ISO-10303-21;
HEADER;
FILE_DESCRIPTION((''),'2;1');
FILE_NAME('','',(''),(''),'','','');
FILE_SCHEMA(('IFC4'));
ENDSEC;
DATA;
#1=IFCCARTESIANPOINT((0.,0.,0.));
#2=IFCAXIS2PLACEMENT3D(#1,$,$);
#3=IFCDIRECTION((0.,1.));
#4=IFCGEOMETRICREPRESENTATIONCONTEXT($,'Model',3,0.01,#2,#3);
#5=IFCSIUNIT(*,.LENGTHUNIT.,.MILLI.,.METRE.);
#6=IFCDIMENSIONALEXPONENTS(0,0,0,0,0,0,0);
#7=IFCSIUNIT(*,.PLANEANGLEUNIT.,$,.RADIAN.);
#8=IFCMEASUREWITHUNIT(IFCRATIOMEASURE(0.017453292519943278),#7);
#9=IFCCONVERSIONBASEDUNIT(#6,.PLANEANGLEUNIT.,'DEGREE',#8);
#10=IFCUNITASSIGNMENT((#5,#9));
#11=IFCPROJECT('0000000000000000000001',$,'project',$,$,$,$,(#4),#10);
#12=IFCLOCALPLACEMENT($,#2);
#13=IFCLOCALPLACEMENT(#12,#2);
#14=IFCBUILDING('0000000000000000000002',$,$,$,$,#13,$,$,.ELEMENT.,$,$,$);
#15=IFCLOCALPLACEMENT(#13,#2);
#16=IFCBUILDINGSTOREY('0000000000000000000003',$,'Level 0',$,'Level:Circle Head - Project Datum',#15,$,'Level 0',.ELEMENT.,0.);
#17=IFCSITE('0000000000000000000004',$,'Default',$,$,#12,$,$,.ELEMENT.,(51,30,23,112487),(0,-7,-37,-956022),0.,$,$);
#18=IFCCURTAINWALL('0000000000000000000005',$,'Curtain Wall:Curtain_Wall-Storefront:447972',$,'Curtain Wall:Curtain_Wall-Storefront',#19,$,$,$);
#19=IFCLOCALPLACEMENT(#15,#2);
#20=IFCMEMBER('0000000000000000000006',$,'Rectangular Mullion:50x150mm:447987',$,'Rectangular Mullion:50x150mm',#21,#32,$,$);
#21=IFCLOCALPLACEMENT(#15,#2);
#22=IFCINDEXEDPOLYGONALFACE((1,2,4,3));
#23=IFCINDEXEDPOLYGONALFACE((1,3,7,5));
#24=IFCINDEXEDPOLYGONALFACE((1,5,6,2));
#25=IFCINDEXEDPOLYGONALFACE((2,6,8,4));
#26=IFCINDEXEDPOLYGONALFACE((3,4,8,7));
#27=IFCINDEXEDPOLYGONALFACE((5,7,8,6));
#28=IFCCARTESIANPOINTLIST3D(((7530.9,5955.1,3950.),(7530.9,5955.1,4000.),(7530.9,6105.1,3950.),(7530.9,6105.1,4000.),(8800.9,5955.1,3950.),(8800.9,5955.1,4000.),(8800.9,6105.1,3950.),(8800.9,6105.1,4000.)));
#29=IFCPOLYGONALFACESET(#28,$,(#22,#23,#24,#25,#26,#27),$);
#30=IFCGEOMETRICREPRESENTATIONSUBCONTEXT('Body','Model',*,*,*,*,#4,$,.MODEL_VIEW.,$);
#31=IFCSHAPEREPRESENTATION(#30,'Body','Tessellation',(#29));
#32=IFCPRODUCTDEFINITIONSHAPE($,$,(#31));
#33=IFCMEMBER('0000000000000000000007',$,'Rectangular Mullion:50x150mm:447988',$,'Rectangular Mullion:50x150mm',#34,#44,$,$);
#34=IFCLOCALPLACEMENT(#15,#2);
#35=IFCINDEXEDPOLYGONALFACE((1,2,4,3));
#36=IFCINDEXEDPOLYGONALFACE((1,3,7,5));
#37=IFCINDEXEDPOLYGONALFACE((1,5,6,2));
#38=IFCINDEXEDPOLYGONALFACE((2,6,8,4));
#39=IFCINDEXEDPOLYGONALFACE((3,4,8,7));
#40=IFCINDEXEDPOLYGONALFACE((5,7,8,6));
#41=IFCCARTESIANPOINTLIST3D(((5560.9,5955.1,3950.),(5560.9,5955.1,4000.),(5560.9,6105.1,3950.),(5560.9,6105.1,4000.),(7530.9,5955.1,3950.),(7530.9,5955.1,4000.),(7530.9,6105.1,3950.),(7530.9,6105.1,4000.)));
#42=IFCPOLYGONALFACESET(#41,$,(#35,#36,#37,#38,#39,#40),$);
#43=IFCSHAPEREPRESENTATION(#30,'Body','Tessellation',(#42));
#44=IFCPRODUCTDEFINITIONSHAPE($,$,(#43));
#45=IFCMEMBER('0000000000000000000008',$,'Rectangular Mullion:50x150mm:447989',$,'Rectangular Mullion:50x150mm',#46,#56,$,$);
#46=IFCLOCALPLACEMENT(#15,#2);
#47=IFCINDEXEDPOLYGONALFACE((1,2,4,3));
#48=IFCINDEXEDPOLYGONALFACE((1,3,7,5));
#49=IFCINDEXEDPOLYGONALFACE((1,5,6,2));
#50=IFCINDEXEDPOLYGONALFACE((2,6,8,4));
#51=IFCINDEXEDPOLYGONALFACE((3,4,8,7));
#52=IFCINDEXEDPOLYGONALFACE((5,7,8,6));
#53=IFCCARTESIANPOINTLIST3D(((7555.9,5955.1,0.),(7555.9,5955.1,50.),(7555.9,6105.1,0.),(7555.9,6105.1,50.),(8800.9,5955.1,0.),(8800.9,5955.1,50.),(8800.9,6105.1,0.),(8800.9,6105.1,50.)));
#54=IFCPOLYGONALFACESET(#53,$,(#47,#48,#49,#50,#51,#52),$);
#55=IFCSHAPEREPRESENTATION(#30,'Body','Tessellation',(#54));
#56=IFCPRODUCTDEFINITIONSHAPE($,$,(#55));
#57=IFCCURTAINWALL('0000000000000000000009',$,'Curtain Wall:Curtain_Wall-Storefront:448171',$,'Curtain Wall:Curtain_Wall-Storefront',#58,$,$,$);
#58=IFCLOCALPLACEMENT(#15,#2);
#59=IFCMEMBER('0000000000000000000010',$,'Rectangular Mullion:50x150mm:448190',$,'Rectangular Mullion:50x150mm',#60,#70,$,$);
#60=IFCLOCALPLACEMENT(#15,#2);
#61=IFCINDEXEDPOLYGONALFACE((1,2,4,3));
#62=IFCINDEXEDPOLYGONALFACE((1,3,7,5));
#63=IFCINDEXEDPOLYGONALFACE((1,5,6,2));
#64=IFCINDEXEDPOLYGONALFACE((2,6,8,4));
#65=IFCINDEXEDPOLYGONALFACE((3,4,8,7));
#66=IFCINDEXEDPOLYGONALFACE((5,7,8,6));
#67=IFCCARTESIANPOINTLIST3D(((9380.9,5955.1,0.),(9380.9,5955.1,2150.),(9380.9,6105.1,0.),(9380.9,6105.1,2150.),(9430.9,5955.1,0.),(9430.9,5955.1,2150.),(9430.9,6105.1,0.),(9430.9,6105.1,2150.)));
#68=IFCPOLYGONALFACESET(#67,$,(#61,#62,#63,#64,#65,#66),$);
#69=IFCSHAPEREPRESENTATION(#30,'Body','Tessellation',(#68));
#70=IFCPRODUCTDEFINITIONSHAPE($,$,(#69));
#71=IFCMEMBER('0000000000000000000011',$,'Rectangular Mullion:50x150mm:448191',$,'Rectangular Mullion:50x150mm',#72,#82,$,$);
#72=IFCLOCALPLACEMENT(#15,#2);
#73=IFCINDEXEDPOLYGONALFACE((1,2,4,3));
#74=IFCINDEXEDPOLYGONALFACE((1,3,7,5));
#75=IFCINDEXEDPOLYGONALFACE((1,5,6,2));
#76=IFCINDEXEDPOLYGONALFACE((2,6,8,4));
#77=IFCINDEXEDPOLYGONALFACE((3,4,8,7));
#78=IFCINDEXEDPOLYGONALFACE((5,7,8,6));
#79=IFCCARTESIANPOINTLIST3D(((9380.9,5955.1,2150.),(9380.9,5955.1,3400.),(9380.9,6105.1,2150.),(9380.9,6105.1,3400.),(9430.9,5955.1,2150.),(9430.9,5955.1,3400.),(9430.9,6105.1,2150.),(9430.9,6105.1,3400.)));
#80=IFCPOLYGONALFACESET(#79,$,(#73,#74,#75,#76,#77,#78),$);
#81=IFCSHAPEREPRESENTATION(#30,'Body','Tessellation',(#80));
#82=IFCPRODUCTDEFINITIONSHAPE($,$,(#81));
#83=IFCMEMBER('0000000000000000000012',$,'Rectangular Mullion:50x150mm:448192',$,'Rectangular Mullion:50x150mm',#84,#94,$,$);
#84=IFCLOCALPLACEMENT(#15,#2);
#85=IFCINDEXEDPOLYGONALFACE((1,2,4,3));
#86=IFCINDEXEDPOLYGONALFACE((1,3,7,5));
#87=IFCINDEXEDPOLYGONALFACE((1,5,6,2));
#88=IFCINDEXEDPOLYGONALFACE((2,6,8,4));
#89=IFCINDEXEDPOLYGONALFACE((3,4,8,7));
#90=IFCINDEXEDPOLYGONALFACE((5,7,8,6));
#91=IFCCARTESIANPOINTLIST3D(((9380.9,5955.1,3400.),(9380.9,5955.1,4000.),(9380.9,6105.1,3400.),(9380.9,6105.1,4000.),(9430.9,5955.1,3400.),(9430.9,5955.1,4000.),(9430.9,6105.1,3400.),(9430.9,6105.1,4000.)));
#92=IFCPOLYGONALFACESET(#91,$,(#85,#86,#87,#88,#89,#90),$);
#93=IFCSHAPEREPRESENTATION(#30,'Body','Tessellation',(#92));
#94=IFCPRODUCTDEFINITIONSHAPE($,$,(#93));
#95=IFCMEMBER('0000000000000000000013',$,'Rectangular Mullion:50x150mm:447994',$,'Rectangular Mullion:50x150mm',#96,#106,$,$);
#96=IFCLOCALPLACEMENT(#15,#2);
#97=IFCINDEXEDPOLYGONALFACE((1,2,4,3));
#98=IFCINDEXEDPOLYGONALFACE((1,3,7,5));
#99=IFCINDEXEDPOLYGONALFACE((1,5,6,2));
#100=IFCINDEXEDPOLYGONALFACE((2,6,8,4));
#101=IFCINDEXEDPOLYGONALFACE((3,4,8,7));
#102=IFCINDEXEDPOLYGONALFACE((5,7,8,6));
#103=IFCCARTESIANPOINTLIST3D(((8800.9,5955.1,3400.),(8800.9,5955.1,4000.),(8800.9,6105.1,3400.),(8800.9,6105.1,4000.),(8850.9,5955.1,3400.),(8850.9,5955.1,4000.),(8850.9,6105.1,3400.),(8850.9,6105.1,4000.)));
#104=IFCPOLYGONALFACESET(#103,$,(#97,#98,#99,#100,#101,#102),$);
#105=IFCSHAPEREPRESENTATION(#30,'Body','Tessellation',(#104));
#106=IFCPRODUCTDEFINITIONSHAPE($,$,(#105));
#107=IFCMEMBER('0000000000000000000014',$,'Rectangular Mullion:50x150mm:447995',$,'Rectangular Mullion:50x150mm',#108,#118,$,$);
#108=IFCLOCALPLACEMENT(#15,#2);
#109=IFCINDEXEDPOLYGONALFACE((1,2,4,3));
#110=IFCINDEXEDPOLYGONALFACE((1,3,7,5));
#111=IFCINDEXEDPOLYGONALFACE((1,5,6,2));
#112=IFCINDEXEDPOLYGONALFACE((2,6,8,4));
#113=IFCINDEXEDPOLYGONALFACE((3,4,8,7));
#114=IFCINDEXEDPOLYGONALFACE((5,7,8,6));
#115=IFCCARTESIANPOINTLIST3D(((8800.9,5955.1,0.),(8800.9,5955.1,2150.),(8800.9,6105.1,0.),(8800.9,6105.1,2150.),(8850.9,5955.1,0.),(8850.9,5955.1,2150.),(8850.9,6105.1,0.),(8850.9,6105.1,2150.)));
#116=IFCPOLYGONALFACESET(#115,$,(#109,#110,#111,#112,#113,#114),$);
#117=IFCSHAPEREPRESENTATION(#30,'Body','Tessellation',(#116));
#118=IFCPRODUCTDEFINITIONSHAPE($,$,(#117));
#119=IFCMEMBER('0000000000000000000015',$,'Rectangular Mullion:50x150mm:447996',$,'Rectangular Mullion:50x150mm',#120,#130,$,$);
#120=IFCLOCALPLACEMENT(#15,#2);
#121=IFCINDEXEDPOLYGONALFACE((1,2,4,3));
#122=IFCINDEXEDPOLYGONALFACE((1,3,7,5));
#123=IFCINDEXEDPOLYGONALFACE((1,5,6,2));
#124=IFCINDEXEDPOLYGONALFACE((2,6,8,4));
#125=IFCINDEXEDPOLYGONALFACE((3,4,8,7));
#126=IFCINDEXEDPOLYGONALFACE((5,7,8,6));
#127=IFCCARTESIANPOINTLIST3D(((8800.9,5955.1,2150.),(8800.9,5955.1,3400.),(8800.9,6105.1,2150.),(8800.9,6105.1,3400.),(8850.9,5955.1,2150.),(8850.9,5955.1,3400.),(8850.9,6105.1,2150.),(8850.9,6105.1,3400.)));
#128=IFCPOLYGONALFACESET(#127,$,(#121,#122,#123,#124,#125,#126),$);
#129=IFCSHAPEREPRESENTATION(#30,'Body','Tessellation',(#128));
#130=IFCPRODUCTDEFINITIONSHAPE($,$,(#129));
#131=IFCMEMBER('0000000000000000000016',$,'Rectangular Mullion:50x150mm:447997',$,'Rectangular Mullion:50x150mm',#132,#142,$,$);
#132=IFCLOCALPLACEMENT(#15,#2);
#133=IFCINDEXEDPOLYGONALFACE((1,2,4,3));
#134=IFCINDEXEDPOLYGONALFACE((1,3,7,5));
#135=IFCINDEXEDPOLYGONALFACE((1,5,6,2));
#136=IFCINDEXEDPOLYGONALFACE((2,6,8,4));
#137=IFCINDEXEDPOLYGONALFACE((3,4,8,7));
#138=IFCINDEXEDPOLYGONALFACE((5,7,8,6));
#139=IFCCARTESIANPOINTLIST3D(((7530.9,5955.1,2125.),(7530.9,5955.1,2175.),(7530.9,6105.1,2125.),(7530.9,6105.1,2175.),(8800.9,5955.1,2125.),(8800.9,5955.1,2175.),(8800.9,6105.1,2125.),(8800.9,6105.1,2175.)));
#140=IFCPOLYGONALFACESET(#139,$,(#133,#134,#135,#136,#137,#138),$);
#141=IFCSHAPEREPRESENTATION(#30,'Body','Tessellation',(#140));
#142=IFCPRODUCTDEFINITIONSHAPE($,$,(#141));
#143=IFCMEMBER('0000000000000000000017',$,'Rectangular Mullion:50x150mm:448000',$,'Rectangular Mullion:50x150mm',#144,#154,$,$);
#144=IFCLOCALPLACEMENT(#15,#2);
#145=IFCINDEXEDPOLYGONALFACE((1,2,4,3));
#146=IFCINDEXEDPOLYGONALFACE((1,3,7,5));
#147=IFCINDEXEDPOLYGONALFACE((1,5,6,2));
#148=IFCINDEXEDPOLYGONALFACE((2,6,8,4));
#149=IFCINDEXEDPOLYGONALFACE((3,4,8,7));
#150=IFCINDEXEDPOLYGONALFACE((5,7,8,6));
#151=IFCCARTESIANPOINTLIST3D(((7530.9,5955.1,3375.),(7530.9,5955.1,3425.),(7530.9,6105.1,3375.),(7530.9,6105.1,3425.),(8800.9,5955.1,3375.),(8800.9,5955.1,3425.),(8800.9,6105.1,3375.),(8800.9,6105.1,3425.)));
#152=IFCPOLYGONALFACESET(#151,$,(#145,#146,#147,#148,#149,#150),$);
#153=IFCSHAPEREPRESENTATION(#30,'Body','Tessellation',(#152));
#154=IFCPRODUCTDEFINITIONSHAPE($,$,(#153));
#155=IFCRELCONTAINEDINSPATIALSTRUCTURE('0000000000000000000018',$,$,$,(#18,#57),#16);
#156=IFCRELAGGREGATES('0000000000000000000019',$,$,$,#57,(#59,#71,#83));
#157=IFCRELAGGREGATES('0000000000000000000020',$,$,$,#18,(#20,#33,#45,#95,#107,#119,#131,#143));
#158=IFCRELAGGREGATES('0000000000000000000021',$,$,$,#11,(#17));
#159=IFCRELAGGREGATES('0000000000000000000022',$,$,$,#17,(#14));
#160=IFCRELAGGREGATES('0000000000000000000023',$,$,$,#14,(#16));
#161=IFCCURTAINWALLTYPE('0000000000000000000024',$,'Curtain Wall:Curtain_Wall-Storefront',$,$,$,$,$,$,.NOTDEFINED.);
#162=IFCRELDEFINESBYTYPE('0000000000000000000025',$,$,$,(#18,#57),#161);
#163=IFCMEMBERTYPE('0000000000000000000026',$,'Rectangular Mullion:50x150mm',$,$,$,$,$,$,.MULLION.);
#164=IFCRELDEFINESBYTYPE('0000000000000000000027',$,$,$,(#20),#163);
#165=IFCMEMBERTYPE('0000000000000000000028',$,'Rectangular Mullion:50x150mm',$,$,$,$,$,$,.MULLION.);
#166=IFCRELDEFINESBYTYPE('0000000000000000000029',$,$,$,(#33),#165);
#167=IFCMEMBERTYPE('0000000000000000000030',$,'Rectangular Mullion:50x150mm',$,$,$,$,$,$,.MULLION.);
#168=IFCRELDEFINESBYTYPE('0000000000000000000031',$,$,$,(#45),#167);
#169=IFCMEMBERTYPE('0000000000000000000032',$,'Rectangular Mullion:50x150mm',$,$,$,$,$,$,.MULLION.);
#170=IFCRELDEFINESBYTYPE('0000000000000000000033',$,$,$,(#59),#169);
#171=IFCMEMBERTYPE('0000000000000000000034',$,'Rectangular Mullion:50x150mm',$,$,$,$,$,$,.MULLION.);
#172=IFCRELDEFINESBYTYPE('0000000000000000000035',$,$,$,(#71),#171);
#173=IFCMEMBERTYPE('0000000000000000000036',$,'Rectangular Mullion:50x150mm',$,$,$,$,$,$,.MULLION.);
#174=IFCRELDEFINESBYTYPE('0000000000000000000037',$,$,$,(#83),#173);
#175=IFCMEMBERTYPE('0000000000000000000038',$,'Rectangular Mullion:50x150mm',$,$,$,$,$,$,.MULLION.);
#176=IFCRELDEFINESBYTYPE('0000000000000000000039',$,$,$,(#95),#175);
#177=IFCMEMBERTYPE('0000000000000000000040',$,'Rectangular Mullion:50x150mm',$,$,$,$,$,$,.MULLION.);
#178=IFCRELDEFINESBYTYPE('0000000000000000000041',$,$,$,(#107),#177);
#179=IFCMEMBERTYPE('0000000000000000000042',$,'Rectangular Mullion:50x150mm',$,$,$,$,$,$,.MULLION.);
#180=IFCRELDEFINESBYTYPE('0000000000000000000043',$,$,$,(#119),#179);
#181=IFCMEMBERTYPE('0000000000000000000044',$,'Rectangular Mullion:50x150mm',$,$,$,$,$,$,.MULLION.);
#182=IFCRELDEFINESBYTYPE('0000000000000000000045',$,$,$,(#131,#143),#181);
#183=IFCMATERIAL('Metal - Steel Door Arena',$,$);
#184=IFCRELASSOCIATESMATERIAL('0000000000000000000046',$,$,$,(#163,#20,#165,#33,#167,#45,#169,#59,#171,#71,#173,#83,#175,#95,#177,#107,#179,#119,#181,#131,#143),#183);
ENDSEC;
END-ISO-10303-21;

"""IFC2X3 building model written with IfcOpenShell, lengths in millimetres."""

from ifc_helpers import new_model, entity, si_unit, converted_unit, direction, frame, origin, origin_2d_with_axis, place, context, subcontext, project, spatial, rectangle, extrude, source, transform, mapped, material, type_object, type_shapes, element, aggregate, save


model = new_model("IFC2X3")

# Units and contexts
model_context = context("Model", 3, precision=0.01, world=origin(), true_north=direction((0.0, 1.0)))
body_context = subcontext(model_context, "Body", "Model", "MODEL_VIEW")
ifc_project = project(units=[si_unit("LENGTHUNIT", "METRE", prefix="MILLI"), converted_unit("PLANEANGLEUNIT", "DEGREE", entity("IfcRatioMeasure", 0.017453292519943278), si_unit("PLANEANGLEUNIT", "RADIAN"), dimensions=[0, 0, 0, 0, 0, 0, 0])], contexts=[model_context])

# Site, building, storey
site_placement = place(None, origin())
site = spatial("IfcSite", under=ifc_project, at=site_placement, Name="Default", CompositionType="ELEMENT", RefLatitude=(51, 30, 23, 112487), RefLongitude=(0, -7, -37, -956022), RefElevation=0.0)
building_placement = place(site_placement, origin())
building = spatial("IfcBuilding", under=site, at=building_placement, CompositionType="ELEMENT")
storey_placement = place(building_placement, origin())
storey = spatial("IfcBuildingStorey", under=building, at=storey_placement, Name="Level 0", ObjectType="Level:Circle Head - Project Datum", LongName="Level 0", CompositionType="ELEMENT", Elevation=0.0)

# Curtain walls, members
curtain_wall_type = type_object("IfcCurtainWallType", Name="Curtain Wall:Curtain_Wall-Storefront", PredefinedType="NOTDEFINED")
curtain_wall_1_placement = place(storey_placement, origin())
curtain_wall_1 = element("IfcCurtainWall", 1, at=curtain_wall_1_placement, inside=storey, type_object=curtain_wall_type, Name="Curtain Wall:Curtain_Wall-Storefront:447972", ObjectType="Curtain Wall:Curtain_Wall-Storefront")
ifc_material_1 = material(Name="Metal - Steel Door Arena")
member_type_1 = type_object("IfcMemberType", Name="Rectangular Mullion:50x150mm", PredefinedType="MULLION", material=ifc_material_1)
shared_shape_1 = source(origin(), body_context, "Body", "SweptSolid", [
    extrude(rectangle(XDim=150.0, YDim=50.0, at=origin_2d_with_axis()), frame((-25.0, 0.0, -1270.0), z_axis=(0.0, 0.0, 1.0), x_axis=(0.0, -1.0, 0.0)), (0.0, 0.0, 1.0), 1270.0),
])
type_shapes(member_type_1, [shared_shape_1])
member_1_placement = place(curtain_wall_1_placement, frame((7530.9, 6030.1, 4000.0), z_axis=(-1.0, 0.0, 0.0), x_axis=(0.0, 0.0, 1.0)))
member_1 = element("IfcMember", 2, at=member_1_placement, type_object=member_type_1, material=ifc_material_1, Name="Rectangular Mullion:50x150mm:447987", ObjectType="Rectangular Mullion:50x150mm", context=body_context, shape_type="MappedRepresentation", body=[
    mapped(shared_shape_1, transform((0.0, 0.0, 0.0), scale=1.0)),
])
member_type_2 = type_object("IfcMemberType", Name="Rectangular Mullion:50x150mm", PredefinedType="MULLION", material=ifc_material_1)
shared_shape_2 = source(origin(), body_context, "Body", "SweptSolid", [
    extrude(rectangle(XDim=150.0, YDim=50.0, at=origin_2d_with_axis()), frame((-25.0, 0.0, -1970.0), z_axis=(0.0, 0.0, 1.0), x_axis=(0.0, -1.0, 0.0)), (0.0, 0.0, 1.0), 1970.0),
])
type_shapes(member_type_2, [shared_shape_2])
member_2_placement = place(curtain_wall_1_placement, frame((5560.9, 6030.1, 4000.0), z_axis=(-1.0, 0.0, 0.0), x_axis=(0.0, 0.0, 1.0)))
member_2 = element("IfcMember", 3, at=member_2_placement, type_object=member_type_2, material=ifc_material_1, Name="Rectangular Mullion:50x150mm:447988", ObjectType="Rectangular Mullion:50x150mm", context=body_context, shape_type="MappedRepresentation", body=[
    mapped(shared_shape_2, transform((0.0, 0.0, 0.0), scale=1.0)),
])
member_type_3 = type_object("IfcMemberType", Name="Rectangular Mullion:50x150mm", PredefinedType="MULLION", material=ifc_material_1)
shared_shape_3 = source(origin(), body_context, "Body", "SweptSolid", [
    extrude(rectangle(XDim=150.0, YDim=50.0, at=origin_2d_with_axis()), frame((-25.0, 0.0, -1245.0), z_axis=(0.0, 0.0, 1.0), x_axis=(0.0, -1.0, 0.0)), (0.0, 0.0, 1.0), 1245.0),
])
type_shapes(member_type_3, [shared_shape_3])
member_3_placement = place(curtain_wall_1_placement, frame((8800.9, 6030.1, 0.0), z_axis=(1.0, 0.0, 0.0), x_axis=(0.0, 0.0, -1.0)))
member_3 = element("IfcMember", 4, at=member_3_placement, type_object=member_type_3, material=ifc_material_1, Name="Rectangular Mullion:50x150mm:447989", ObjectType="Rectangular Mullion:50x150mm", context=body_context, shape_type="MappedRepresentation", body=[
    mapped(shared_shape_3, transform((0.0, 0.0, 0.0), scale=1.0)),
])
curtain_wall_2_placement = place(storey_placement, origin())
curtain_wall_2 = element("IfcCurtainWall", 5, at=curtain_wall_2_placement, inside=storey, type_object=curtain_wall_type, Name="Curtain Wall:Curtain_Wall-Storefront:448171", ObjectType="Curtain Wall:Curtain_Wall-Storefront")
member_type_4 = type_object("IfcMemberType", Name="Rectangular Mullion:50x150mm", PredefinedType="MULLION", material=ifc_material_1)
shared_shape_4 = source(origin(), body_context, "Body", "SweptSolid", [
    extrude(rectangle(XDim=150.0, YDim=50.0, at=origin_2d_with_axis()), frame((-25.0, 0.0, -2150.0), z_axis=(0.0, 0.0, 1.0), x_axis=(0.0, -1.0, 0.0)), (0.0, 0.0, 1.0), 2150.0),
])
type_shapes(member_type_4, [shared_shape_4])
member_4_placement = place(curtain_wall_2_placement, frame((9380.9, 6030.1, 0.0), z_axis=(0.0, 0.0, -1.0), x_axis=(-1.0, 0.0, 0.0)))
member_4 = element("IfcMember", 6, at=member_4_placement, type_object=member_type_4, material=ifc_material_1, Name="Rectangular Mullion:50x150mm:448190", ObjectType="Rectangular Mullion:50x150mm", context=body_context, shape_type="MappedRepresentation", body=[
    mapped(shared_shape_4, transform((0.0, 0.0, 0.0), scale=1.0)),
])
member_type_5 = type_object("IfcMemberType", Name="Rectangular Mullion:50x150mm", PredefinedType="MULLION", material=ifc_material_1)
shared_shape_5 = source(origin(), body_context, "Body", "SweptSolid", [
    extrude(rectangle(XDim=150.0, YDim=50.0, at=origin_2d_with_axis()), frame((-25.0, 0.0, -1250.0), z_axis=(0.0, 0.0, 1.0), x_axis=(0.0, -1.0, 0.0)), (0.0, 0.0, 1.0), 1250.0),
])
type_shapes(member_type_5, [shared_shape_5])
member_5_placement = place(curtain_wall_2_placement, frame((9380.9, 6030.1, 2150.0), z_axis=(0.0, 0.0, -1.0), x_axis=(-1.0, 0.0, 0.0)))
member_5 = element("IfcMember", 7, at=member_5_placement, type_object=member_type_5, material=ifc_material_1, Name="Rectangular Mullion:50x150mm:448191", ObjectType="Rectangular Mullion:50x150mm", context=body_context, shape_type="MappedRepresentation", body=[
    mapped(shared_shape_5, transform((0.0, 0.0, 0.0), scale=1.0)),
])
member_type_6 = type_object("IfcMemberType", Name="Rectangular Mullion:50x150mm", PredefinedType="MULLION", material=ifc_material_1)
shared_shape_6 = source(origin(), body_context, "Body", "SweptSolid", [
    extrude(rectangle(XDim=150.0, YDim=50.0, at=origin_2d_with_axis()), frame((-25.0, 0.0, -600.0), z_axis=(0.0, 0.0, 1.0), x_axis=(0.0, -1.0, 0.0)), (0.0, 0.0, 1.0), 600.0),
])
type_shapes(member_type_6, [shared_shape_6])
member_6_placement = place(curtain_wall_2_placement, frame((9380.9, 6030.1, 3400.0), z_axis=(0.0, 0.0, -1.0), x_axis=(-1.0, 0.0, 0.0)))
member_6 = element("IfcMember", 8, at=member_6_placement, type_object=member_type_6, material=ifc_material_1, Name="Rectangular Mullion:50x150mm:448192", ObjectType="Rectangular Mullion:50x150mm", context=body_context, shape_type="MappedRepresentation", body=[
    mapped(shared_shape_6, transform((0.0, 0.0, 0.0), scale=1.0)),
])
aggregate(curtain_wall_2, [member_4, member_5, member_6])

# Members
member_type_7 = type_object("IfcMemberType", Name="Rectangular Mullion:50x150mm", PredefinedType="MULLION", material=ifc_material_1)
shared_shape_7 = source(origin(), body_context, "Body", "SweptSolid", [
    extrude(rectangle(XDim=150.0, YDim=50.0, at=origin_2d_with_axis()), frame((-25.0, 0.0, -600.0), z_axis=(0.0, 0.0, 1.0), x_axis=(0.0, -1.0, 0.0)), (0.0, 0.0, 1.0), 600.0),
])
type_shapes(member_type_7, [shared_shape_7])
member_7_placement = place(curtain_wall_1_placement, frame((8850.9, 6030.1, 4000.0)))
member_7 = element("IfcMember", 9, at=member_7_placement, type_object=member_type_7, material=ifc_material_1, Name="Rectangular Mullion:50x150mm:447994", ObjectType="Rectangular Mullion:50x150mm", context=body_context, shape_type="MappedRepresentation", body=[
    mapped(shared_shape_7, transform((0.0, 0.0, 0.0), scale=1.0)),
])
member_type_8 = type_object("IfcMemberType", Name="Rectangular Mullion:50x150mm", PredefinedType="MULLION", material=ifc_material_1)
shared_shape_8 = source(origin(), body_context, "Body", "SweptSolid", [
    extrude(rectangle(XDim=150.0, YDim=50.0, at=origin_2d_with_axis()), frame((-25.0, 0.0, -2150.0), z_axis=(0.0, 0.0, 1.0), x_axis=(0.0, -1.0, 0.0)), (0.0, 0.0, 1.0), 2150.0),
])
type_shapes(member_type_8, [shared_shape_8])
member_8_placement = place(curtain_wall_1_placement, frame((8850.9, 6030.1, 2150.0)))
member_8 = element("IfcMember", 10, at=member_8_placement, type_object=member_type_8, material=ifc_material_1, Name="Rectangular Mullion:50x150mm:447995", ObjectType="Rectangular Mullion:50x150mm", context=body_context, shape_type="MappedRepresentation", body=[
    mapped(shared_shape_8, transform((0.0, 0.0, 0.0), scale=1.0)),
])
member_type_9 = type_object("IfcMemberType", Name="Rectangular Mullion:50x150mm", PredefinedType="MULLION", material=ifc_material_1)
shared_shape_9 = source(origin(), body_context, "Body", "SweptSolid", [
    extrude(rectangle(XDim=150.0, YDim=50.0, at=origin_2d_with_axis()), frame((-25.0, 0.0, -1250.0), z_axis=(0.0, 0.0, 1.0), x_axis=(0.0, -1.0, 0.0)), (0.0, 0.0, 1.0), 1250.0),
])
type_shapes(member_type_9, [shared_shape_9])
member_9_placement = place(curtain_wall_1_placement, frame((8850.9, 6030.1, 3400.0)))
member_9 = element("IfcMember", 11, at=member_9_placement, type_object=member_type_9, material=ifc_material_1, Name="Rectangular Mullion:50x150mm:447996", ObjectType="Rectangular Mullion:50x150mm", context=body_context, shape_type="MappedRepresentation", body=[
    mapped(shared_shape_9, transform((0.0, 0.0, 0.0), scale=1.0)),
])
member_type_10 = type_object("IfcMemberType", Name="Rectangular Mullion:50x150mm", PredefinedType="MULLION", material=ifc_material_1)
shared_shape_10 = source(origin(), body_context, "Body", "SweptSolid", [
    extrude(rectangle(XDim=150.0, YDim=50.0, at=origin_2d_with_axis()), frame((0.0, 0.0, -1270.0), z_axis=(0.0, 0.0, 1.0), x_axis=(0.0, -1.0, 0.0)), (0.0, 0.0, 1.0), 1270.0),
])
type_shapes(member_type_10, [shared_shape_10])
member_10_placement = place(curtain_wall_1_placement, frame((7530.9, 6030.1, 2150.0), z_axis=(-1.0, 0.0, 0.0), x_axis=(0.0, 0.0, 1.0)))
member_10 = element("IfcMember", 12, at=member_10_placement, type_object=member_type_10, material=ifc_material_1, Name="Rectangular Mullion:50x150mm:447997", ObjectType="Rectangular Mullion:50x150mm", context=body_context, shape_type="MappedRepresentation", body=[
    mapped(shared_shape_10, transform((0.0, 0.0, 0.0), scale=1.0)),
])
member_11_placement = place(curtain_wall_1_placement, frame((7530.9, 6030.1, 3400.0), z_axis=(-1.0, 0.0, 0.0), x_axis=(0.0, 0.0, 1.0)))
member_11 = element("IfcMember", 13, at=member_11_placement, type_object=member_type_10, material=ifc_material_1, Name="Rectangular Mullion:50x150mm:448000", ObjectType="Rectangular Mullion:50x150mm", context=body_context, shape_type="MappedRepresentation", body=[
    mapped(shared_shape_10, transform((0.0, 0.0, 0.0), scale=1.0)),
])

aggregate(curtain_wall_1, [member_1, member_2, member_3, member_7, member_8, member_9, member_10, member_11])

save(model, "model.ifc")
